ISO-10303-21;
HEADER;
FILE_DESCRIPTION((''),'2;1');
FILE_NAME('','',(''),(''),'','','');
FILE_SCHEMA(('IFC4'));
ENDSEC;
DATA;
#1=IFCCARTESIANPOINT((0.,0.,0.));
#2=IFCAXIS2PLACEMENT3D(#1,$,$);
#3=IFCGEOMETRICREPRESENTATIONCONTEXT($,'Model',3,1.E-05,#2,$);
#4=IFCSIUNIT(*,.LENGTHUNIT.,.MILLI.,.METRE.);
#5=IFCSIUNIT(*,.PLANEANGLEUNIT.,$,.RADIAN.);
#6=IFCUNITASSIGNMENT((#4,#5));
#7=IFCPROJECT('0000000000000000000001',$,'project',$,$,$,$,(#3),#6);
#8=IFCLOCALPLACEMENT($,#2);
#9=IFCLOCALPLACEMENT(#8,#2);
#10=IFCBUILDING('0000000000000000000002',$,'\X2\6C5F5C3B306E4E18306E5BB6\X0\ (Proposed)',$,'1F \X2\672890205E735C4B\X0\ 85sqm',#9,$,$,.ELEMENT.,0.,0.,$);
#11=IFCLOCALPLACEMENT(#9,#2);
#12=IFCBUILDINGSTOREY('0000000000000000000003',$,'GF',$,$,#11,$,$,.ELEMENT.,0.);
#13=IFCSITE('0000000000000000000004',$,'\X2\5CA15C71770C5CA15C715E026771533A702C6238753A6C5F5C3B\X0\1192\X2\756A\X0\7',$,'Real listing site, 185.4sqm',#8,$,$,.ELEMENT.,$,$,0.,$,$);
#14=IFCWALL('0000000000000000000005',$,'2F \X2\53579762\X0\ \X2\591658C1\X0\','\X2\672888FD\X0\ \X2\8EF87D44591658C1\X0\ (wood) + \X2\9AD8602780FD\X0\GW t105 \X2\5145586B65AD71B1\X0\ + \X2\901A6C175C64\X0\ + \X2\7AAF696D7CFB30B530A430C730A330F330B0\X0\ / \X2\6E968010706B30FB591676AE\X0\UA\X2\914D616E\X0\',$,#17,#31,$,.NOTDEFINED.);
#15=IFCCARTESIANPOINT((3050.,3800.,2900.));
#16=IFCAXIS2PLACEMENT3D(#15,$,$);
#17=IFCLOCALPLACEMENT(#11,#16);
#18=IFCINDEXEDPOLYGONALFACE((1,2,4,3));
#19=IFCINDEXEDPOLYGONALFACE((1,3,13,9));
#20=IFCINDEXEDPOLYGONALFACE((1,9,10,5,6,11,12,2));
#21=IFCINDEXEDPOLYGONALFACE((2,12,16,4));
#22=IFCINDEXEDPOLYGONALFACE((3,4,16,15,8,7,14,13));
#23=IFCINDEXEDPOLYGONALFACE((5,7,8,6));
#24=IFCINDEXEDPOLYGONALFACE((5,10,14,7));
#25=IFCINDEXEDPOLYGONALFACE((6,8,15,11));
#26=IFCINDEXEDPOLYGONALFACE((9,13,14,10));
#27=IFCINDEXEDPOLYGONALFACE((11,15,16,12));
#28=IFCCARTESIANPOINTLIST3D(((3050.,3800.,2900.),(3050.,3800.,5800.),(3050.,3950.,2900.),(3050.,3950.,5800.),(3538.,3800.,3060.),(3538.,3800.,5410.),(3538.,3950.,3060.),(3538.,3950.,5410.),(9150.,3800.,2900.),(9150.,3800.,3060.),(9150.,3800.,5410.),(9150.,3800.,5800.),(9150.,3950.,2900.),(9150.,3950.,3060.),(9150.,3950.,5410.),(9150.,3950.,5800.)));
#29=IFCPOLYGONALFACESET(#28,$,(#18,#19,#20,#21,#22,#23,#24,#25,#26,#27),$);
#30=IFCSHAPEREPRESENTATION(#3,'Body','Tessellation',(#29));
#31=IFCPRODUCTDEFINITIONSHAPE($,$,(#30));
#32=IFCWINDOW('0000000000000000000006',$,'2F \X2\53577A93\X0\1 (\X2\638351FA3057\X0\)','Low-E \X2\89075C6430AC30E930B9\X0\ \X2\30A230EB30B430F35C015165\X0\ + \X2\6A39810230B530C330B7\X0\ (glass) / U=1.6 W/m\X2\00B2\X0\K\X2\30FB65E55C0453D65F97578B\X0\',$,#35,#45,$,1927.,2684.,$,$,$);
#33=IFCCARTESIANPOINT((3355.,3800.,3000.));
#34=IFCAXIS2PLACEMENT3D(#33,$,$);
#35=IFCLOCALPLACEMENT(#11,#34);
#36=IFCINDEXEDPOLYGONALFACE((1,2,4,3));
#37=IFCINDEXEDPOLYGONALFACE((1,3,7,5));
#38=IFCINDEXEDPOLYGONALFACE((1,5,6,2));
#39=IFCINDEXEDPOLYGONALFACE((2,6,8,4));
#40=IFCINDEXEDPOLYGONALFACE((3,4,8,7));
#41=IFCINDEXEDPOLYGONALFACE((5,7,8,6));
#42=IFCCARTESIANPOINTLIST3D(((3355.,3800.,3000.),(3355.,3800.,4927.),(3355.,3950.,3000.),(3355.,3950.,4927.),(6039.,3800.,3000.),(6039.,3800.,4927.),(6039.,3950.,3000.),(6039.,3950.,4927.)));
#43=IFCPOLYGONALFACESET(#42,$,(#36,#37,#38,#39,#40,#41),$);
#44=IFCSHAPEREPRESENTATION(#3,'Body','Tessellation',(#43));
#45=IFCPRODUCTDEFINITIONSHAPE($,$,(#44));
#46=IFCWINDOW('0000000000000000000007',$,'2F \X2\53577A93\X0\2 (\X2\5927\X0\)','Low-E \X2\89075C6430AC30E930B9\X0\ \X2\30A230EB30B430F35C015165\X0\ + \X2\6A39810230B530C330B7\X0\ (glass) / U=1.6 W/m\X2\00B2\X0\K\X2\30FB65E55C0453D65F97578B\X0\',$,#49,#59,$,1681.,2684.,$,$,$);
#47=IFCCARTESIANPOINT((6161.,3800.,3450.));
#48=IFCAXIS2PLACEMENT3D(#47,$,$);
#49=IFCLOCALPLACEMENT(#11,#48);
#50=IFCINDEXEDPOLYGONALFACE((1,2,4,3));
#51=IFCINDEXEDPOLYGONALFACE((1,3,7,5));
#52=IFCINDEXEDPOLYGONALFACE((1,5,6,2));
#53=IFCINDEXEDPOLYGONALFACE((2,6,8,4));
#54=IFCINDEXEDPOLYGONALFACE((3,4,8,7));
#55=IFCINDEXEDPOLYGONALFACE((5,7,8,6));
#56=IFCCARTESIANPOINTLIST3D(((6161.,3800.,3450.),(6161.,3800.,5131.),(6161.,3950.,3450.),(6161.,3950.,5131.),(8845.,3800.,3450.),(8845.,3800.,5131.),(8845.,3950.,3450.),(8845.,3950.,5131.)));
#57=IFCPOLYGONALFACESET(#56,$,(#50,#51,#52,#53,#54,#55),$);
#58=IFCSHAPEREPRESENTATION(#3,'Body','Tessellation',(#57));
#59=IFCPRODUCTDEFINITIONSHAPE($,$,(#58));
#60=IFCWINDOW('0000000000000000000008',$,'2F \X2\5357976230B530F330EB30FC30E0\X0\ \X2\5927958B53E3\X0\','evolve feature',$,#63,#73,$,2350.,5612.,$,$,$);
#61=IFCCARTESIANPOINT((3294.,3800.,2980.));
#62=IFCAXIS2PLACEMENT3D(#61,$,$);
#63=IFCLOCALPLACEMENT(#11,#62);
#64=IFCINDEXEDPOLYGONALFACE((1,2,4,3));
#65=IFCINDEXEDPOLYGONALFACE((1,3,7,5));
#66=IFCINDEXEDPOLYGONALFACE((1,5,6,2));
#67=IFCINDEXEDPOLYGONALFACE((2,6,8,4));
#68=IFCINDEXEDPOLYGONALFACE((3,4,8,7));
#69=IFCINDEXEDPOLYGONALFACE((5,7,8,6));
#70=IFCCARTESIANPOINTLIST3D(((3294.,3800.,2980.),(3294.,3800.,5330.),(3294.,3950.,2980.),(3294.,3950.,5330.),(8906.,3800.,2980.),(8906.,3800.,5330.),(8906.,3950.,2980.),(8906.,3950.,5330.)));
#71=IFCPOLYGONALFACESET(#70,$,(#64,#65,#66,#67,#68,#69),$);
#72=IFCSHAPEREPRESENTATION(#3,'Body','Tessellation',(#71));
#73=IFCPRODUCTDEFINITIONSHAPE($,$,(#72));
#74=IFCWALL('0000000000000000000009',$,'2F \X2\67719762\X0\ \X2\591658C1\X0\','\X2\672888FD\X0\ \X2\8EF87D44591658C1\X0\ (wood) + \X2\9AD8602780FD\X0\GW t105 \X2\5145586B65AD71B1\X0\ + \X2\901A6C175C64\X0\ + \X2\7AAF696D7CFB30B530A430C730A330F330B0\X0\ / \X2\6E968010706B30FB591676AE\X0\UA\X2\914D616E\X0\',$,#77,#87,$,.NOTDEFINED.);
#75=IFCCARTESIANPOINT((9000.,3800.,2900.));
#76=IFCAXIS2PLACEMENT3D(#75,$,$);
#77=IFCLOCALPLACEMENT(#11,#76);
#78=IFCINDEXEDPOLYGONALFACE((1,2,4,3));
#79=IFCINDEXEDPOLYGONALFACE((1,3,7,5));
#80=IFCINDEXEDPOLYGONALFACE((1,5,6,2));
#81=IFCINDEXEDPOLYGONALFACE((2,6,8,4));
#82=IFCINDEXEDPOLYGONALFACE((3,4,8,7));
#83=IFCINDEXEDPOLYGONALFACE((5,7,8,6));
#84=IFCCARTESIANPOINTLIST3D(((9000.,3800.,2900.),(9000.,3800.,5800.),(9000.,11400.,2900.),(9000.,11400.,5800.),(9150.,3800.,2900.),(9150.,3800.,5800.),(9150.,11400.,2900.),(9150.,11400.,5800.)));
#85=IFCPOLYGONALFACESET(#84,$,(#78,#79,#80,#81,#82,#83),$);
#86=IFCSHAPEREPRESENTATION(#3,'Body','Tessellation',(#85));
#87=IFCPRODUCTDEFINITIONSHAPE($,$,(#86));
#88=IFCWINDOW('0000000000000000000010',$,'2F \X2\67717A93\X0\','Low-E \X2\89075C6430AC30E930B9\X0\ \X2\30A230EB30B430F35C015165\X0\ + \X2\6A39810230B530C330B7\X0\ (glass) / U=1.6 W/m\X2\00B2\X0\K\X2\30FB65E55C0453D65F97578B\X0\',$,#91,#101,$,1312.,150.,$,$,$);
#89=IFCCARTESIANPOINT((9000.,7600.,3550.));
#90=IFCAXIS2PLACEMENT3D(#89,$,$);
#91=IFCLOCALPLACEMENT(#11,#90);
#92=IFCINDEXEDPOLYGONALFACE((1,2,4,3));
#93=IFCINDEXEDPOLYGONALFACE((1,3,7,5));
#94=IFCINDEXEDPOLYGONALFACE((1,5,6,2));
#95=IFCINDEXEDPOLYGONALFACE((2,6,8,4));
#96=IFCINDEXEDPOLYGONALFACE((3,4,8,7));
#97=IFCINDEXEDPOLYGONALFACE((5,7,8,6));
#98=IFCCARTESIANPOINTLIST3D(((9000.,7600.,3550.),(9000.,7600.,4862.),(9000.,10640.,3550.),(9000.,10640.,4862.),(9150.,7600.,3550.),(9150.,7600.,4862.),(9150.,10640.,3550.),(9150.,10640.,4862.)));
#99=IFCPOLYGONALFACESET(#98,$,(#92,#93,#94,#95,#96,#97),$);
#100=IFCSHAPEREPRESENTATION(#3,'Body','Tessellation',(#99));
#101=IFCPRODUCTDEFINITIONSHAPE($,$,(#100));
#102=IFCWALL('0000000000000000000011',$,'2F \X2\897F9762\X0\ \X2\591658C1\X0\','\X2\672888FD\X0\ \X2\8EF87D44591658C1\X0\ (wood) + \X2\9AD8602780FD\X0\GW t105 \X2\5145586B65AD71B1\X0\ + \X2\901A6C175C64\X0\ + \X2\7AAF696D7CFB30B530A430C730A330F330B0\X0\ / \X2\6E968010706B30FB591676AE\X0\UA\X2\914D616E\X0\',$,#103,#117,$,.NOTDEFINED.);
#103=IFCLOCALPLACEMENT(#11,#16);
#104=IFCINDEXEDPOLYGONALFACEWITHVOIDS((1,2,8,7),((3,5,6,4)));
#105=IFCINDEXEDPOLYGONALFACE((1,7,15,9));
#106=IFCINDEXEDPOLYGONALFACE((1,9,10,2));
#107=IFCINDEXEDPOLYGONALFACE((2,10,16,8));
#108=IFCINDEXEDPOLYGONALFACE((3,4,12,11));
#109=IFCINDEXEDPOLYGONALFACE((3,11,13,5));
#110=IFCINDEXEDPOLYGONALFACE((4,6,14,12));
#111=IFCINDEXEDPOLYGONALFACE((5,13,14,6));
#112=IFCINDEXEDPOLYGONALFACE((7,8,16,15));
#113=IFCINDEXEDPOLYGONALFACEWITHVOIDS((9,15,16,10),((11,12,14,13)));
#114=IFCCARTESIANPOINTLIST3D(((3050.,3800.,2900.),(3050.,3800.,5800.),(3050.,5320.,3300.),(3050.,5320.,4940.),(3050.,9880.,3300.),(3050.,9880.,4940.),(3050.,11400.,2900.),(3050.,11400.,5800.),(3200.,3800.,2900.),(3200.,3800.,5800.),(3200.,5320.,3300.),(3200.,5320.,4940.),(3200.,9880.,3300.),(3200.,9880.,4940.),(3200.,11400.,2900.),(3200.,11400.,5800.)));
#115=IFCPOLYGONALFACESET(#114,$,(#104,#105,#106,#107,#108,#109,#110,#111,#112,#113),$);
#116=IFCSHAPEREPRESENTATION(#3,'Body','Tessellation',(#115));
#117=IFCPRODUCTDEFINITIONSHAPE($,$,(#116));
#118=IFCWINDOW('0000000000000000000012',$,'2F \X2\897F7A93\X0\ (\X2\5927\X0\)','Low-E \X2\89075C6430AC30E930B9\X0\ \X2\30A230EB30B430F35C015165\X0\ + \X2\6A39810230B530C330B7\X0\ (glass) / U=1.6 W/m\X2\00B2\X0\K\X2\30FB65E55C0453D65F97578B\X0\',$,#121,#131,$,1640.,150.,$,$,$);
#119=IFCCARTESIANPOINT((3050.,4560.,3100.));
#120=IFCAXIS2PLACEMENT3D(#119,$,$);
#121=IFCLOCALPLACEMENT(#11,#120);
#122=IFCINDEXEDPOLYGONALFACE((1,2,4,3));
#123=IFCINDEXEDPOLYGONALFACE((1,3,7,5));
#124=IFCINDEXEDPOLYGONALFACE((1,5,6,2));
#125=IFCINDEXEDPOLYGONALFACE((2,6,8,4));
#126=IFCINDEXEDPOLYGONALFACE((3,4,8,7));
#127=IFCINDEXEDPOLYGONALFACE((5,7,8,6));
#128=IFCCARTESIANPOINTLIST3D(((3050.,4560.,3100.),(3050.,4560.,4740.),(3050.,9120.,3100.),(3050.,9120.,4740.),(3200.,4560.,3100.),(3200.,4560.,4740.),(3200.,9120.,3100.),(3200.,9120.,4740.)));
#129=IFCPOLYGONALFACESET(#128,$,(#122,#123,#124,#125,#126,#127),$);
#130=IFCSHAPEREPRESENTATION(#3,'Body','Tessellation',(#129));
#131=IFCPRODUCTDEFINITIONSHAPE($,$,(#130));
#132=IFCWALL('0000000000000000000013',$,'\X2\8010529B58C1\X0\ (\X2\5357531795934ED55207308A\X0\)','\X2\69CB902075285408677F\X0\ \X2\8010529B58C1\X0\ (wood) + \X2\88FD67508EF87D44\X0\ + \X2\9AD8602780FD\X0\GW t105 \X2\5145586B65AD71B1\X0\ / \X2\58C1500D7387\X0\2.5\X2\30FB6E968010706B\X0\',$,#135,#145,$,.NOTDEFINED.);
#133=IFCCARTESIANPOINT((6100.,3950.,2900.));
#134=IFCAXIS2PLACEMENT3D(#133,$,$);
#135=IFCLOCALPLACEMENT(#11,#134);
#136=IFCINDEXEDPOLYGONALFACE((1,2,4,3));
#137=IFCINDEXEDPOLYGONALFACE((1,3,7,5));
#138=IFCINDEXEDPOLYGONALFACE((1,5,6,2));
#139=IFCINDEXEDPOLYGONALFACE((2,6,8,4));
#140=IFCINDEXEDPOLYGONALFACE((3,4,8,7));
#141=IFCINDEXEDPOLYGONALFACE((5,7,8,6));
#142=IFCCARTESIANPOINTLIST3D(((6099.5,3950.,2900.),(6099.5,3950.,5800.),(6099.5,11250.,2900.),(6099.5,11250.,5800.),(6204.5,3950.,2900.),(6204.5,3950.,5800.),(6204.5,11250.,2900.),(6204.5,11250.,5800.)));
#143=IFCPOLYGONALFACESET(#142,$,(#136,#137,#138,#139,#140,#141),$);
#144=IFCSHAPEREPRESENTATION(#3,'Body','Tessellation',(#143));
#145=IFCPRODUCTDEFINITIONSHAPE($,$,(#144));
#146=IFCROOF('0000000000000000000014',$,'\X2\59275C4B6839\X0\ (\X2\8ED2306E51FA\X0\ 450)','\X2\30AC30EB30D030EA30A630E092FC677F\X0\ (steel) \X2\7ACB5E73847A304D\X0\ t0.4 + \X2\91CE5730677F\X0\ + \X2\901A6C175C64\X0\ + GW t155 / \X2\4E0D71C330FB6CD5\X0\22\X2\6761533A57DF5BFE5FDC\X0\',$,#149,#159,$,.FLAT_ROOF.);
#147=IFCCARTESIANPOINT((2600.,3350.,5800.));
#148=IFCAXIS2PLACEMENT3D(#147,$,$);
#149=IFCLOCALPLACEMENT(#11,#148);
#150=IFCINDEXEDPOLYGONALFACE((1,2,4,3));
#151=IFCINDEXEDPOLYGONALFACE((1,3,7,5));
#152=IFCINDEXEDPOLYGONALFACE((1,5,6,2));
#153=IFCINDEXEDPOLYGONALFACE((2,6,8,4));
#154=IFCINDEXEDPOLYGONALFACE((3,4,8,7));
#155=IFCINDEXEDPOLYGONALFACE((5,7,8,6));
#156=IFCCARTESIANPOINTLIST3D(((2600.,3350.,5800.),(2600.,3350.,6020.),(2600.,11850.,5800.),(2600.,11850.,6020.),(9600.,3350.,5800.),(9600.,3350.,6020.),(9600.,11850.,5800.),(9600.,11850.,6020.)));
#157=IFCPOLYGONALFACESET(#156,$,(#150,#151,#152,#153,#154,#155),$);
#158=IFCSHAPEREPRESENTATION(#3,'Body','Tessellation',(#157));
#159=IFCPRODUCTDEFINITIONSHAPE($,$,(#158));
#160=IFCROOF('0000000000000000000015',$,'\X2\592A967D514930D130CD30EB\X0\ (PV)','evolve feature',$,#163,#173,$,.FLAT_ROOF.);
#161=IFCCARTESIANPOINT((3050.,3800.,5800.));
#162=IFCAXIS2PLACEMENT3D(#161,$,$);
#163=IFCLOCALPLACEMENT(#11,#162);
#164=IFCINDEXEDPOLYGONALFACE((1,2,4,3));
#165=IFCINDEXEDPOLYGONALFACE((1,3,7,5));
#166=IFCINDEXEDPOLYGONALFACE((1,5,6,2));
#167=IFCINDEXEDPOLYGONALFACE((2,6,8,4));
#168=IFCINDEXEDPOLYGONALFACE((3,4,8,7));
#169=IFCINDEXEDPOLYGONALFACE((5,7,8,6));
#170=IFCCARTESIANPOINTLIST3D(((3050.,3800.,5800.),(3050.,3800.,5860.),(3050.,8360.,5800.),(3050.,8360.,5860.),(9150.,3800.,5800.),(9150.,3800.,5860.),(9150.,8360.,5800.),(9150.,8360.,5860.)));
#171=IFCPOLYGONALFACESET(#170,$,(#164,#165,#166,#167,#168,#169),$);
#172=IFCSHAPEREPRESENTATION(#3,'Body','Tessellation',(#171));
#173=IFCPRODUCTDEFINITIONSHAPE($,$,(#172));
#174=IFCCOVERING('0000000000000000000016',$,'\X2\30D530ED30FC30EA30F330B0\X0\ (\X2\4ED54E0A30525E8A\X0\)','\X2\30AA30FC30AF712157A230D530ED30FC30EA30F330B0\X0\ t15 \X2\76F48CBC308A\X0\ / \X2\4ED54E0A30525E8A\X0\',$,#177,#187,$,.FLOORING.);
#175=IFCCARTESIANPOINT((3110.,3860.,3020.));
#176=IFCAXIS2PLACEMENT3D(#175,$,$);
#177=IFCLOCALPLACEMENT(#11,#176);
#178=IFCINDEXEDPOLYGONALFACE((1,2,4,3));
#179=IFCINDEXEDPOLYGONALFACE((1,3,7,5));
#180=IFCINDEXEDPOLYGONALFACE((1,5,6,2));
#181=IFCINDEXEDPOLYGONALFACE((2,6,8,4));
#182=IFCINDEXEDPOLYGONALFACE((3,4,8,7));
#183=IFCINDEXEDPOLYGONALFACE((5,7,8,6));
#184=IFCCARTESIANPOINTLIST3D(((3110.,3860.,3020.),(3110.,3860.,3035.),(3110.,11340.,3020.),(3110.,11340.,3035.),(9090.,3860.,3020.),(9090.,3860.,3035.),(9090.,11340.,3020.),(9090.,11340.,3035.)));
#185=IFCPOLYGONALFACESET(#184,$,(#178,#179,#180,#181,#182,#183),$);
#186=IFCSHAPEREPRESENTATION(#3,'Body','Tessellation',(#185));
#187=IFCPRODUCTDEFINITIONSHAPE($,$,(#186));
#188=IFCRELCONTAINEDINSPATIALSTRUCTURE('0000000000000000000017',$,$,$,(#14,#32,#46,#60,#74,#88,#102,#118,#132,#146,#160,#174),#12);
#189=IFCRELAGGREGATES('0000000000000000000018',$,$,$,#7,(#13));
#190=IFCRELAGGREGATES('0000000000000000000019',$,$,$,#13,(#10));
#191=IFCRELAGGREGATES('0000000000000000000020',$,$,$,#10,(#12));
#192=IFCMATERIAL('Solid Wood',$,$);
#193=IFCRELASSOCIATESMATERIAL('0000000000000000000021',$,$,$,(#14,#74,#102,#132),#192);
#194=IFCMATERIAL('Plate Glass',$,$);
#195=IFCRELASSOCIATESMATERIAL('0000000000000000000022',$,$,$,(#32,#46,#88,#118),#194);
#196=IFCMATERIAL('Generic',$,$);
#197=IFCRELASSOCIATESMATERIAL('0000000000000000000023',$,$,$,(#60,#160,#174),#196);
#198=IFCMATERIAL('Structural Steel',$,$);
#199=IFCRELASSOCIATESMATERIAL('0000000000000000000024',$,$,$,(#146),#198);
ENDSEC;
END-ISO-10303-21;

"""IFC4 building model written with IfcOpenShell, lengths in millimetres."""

from ifc_helpers import new_model, si_unit, frame, frame_2d, origin, place, context, project, spatial, rectangle, extrude, material, element, fill, save


model = new_model("IFC4")

# Units and contexts
model_context = context("Model", 3, precision=1e-05, world=origin())
ifc_project = project(units=[si_unit("LENGTHUNIT", "METRE", prefix="MILLI"), si_unit("PLANEANGLEUNIT", "RADIAN")], contexts=[model_context])

# Site, building, storey
site_placement = place(None, origin())
site = spatial("IfcSite", under=ifc_project, at=site_placement, Name="岡山県岡山市東区瀬戸町江尻1192番7", ObjectType="Real listing site, 185.4sqm", CompositionType="ELEMENT", RefElevation=0.0)
building_placement = place(site_placement, origin())
building = spatial("IfcBuilding", under=site, at=building_placement, Name="江尻の丘の家 (Proposed)", ObjectType="1F 木造平屋 85sqm", CompositionType="ELEMENT", ElevationOfRefHeight=0.0, ElevationOfTerrain=0.0)
storey_placement = place(building_placement, origin())
storey = spatial("IfcBuildingStorey", under=building, at=storey_placement, Name="GF", CompositionType="ELEMENT", Elevation=0.0)

# Shared definitions
ifc_material_1 = material(Name="Solid Wood")

# Wall, openings, windows
wall_1_placement = place(storey_placement, frame((3050.0, 3800.0, 2900.0)))
wall_1 = element("IfcWall", 1, at=wall_1_placement, inside=storey, material=ifc_material_1, Name="2F 南面 外壁", Description="木製 軸組外壁 (wood) + 高性能GW t105 充填断熱 + 通気層 + 窯業系サイディング / 準耐火・外皮UA配慮", PredefinedType="NOTDEFINED", context=model_context, shape_type="SweptSolid", body=[
    extrude(rectangle(XDim=6100.0, YDim=150.0, at=frame_2d((3050.0, 75.0))), frame((3050.0, 3800.0, 2900.0)), (0.0, 0.0, 1.0), 2900.0),
])
opening_1_placement = place(storey_placement, frame((3355.0, 3800.0, 3000.0)))
opening_1 = element("IfcOpeningElement", 2, at=opening_1_placement, cuts=wall_1, PredefinedType="NOTDEFINED", context=model_context, shape_type="SweptSolid", body=[
    extrude(rectangle(XDim=2684.0, YDim=150.0, at=frame_2d((1342.0, 75.0))), frame((3355.0, 3800.0, 3000.0)), (0.0, 0.0, 1.0), 1927.0),
])
opening_2_placement = place(storey_placement, frame((6161.0, 3800.0, 3450.0)))
opening_2 = element("IfcOpeningElement", 3, at=opening_2_placement, cuts=wall_1, PredefinedType="NOTDEFINED", context=model_context, shape_type="SweptSolid", body=[
    extrude(rectangle(XDim=2684.0, YDim=150.0, at=frame_2d((1342.0, 75.0))), frame((6161.0, 3800.0, 3450.0)), (0.0, 0.0, 1.0), 1681.0),
])
opening_3_placement = place(storey_placement, frame((3294.0, 3800.0, 2980.0)))
opening_3 = element("IfcOpeningElement", 4, at=opening_3_placement, cuts=wall_1, PredefinedType="NOTDEFINED", context=model_context, shape_type="SweptSolid", body=[
    extrude(rectangle(XDim=5612.0, YDim=150.0, at=frame_2d((2806.0, 75.0))), frame((3294.0, 3800.0, 2980.0)), (0.0, 0.0, 1.0), 2350.0),
])
ifc_material_2 = material(Name="Plate Glass")
window_1_placement = place(storey_placement, frame((3355.0, 3800.0, 3000.0)))
window_1 = element("IfcWindow", 5, at=window_1_placement, inside=storey, material=ifc_material_2, Name="2F 南窓1 (掃出し)", Description="Low-E 複層ガラス アルゴン封入 + 樹脂サッシ (glass) / U=1.6 W/m²K・日射取得型", OverallHeight=1927.0, OverallWidth=2684.0, context=model_context, shape_type="SweptSolid", body=[
    extrude(rectangle(XDim=2684.0, YDim=150.0, at=frame_2d((1342.0, 75.0))), frame((3355.0, 3800.0, 3000.0)), (0.0, 0.0, 1.0), 1927.0),
])
fill(opening_1, window_1)
window_2_placement = place(storey_placement, frame((6161.0, 3800.0, 3450.0)))
window_2 = element("IfcWindow", 6, at=window_2_placement, inside=storey, material=ifc_material_2, Name="2F 南窓2 (大)", Description="Low-E 複層ガラス アルゴン封入 + 樹脂サッシ (glass) / U=1.6 W/m²K・日射取得型", OverallHeight=1681.0, OverallWidth=2684.0, context=model_context, shape_type="SweptSolid", body=[
    extrude(rectangle(XDim=2684.0, YDim=150.0, at=frame_2d((1342.0, 75.0))), frame((6161.0, 3800.0, 3450.0)), (0.0, 0.0, 1.0), 1681.0),
])
fill(opening_2, window_2)
ifc_material_3 = material(Name="Generic")
window_3_placement = place(storey_placement, frame((3294.0, 3800.0, 2980.0)))
window_3 = element("IfcWindow", 7, at=window_3_placement, inside=storey, material=ifc_material_3, Name="2F 南面サンルーム 大開口", Description="evolve feature", OverallHeight=2350.0, OverallWidth=5612.0, context=model_context, shape_type="SweptSolid", body=[
    extrude(rectangle(XDim=5612.0, YDim=150.0, at=frame_2d((2806.0, 75.0))), frame((3294.0, 3800.0, 2980.0)), (0.0, 0.0, 1.0), 2350.0),
])
fill(opening_3, window_3)

# Walls, openings, windows
wall_2_placement = place(storey_placement, frame((9000.0, 3800.0, 2900.0)))
wall_2 = element("IfcWall", 8, at=wall_2_placement, inside=storey, material=ifc_material_1, Name="2F 東面 外壁", Description="木製 軸組外壁 (wood) + 高性能GW t105 充填断熱 + 通気層 + 窯業系サイディング / 準耐火・外皮UA配慮", PredefinedType="NOTDEFINED", context=model_context, shape_type="SweptSolid", body=[
    extrude(rectangle(XDim=150.0, YDim=7600.0, at=frame_2d((75.0, 3800.0))), frame((9000.0, 3800.0, 2900.0)), (0.0, 0.0, 1.0), 2900.0),
])
opening_4_placement = place(storey_placement, frame((9000.0, 7600.0, 3550.0)))
opening_4 = element("IfcOpeningElement", 9, at=opening_4_placement, cuts=wall_2, PredefinedType="NOTDEFINED", context=model_context, shape_type="SweptSolid", body=[
    extrude(rectangle(XDim=150.0, YDim=3040.0, at=frame_2d((75.0, 1520.0))), frame((9000.0, 7600.0, 3550.0)), (0.0, 0.0, 1.0), 1312.0),
])
window_4_placement = place(storey_placement, frame((9000.0, 7600.0, 3550.0)))
window_4 = element("IfcWindow", 10, at=window_4_placement, inside=storey, material=ifc_material_2, Name="2F 東窓", Description="Low-E 複層ガラス アルゴン封入 + 樹脂サッシ (glass) / U=1.6 W/m²K・日射取得型", OverallHeight=1312.0, OverallWidth=150.0, context=model_context, shape_type="SweptSolid", body=[
    extrude(rectangle(XDim=150.0, YDim=3040.0, at=frame_2d((75.0, 1520.0))), frame((9000.0, 7600.0, 3550.0)), (0.0, 0.0, 1.0), 1312.0),
])
fill(opening_4, window_4)
wall_3_placement = place(storey_placement, frame((3050.0, 3800.0, 2900.0)))
wall_3 = element("IfcWall", 11, at=wall_3_placement, inside=storey, material=ifc_material_1, Name="2F 西面 外壁", Description="木製 軸組外壁 (wood) + 高性能GW t105 充填断熱 + 通気層 + 窯業系サイディング / 準耐火・外皮UA配慮", PredefinedType="NOTDEFINED", context=model_context, shape_type="SweptSolid", body=[
    extrude(rectangle(XDim=150.0, YDim=7600.0, at=frame_2d((75.0, 3800.0))), frame((3050.0, 3800.0, 2900.0)), (0.0, 0.0, 1.0), 2900.0),
])
opening_5_placement = place(storey_placement, frame((3050.0, 4560.0, 3100.0)))
opening_5 = element("IfcOpeningElement", 12, at=opening_5_placement, cuts=wall_3, PredefinedType="NOTDEFINED", context=model_context, shape_type="SweptSolid", body=[
    extrude(rectangle(XDim=150.0, YDim=4560.0, at=frame_2d((75.0, 2280.0))), frame((3050.0, 4560.0, 3100.0)), (0.0, 0.0, 1.0), 1640.0),
])
window_5_placement = place(storey_placement, frame((3050.0, 4560.0, 3100.0)))
window_5 = element("IfcWindow", 13, at=window_5_placement, inside=storey, material=ifc_material_2, Name="2F 西窓 (大)", Description="Low-E 複層ガラス アルゴン封入 + 樹脂サッシ (glass) / U=1.6 W/m²K・日射取得型", OverallHeight=1640.0, OverallWidth=150.0, context=model_context, shape_type="SweptSolid", body=[
    extrude(rectangle(XDim=150.0, YDim=4560.0, at=frame_2d((75.0, 2280.0))), frame((3050.0, 4560.0, 3100.0)), (0.0, 0.0, 1.0), 1640.0),
])
fill(opening_5, window_5)

# Wall
wall_4_placement = place(storey_placement, frame((6100.0, 3950.0, 2900.0)))
element("IfcWall", 14, at=wall_4_placement, inside=storey, material=ifc_material_1, Name="耐力壁 (南北間仕切り)", Description="構造用合板 耐力壁 (wood) + 製材軸組 + 高性能GW t105 充填断熱 / 壁倍率2.5・準耐火", PredefinedType="NOTDEFINED", context=model_context, shape_type="SweptSolid", body=[
    extrude(rectangle(XDim=105.0, YDim=7300.0, at=frame_2d((52.0, 3650.0))), frame((6100.0, 3950.0, 2900.0)), (0.0, 0.0, 1.0), 2900.0),
])

# Roofs
ifc_material_4 = material(Name="Structural Steel")
roof_1_placement = place(storey_placement, frame((2600.0, 3350.0, 5800.0)))
element("IfcRoof", 15, at=roof_1_placement, inside=storey, material=ifc_material_4, Name="大屋根 (軒の出 450)", Description="ガルバリウム鋼板 (steel) 立平葺き t0.4 + 野地板 + 通気層 + GW t155 / 不燃・法22条区域対応", PredefinedType="FLAT_ROOF", context=model_context, shape_type="SweptSolid", body=[
    extrude(rectangle(XDim=7000.0, YDim=8500.0, at=frame_2d((3500.0, 4250.0))), frame((2600.0, 3350.0, 5800.0)), (0.0, 0.0, 1.0), 220.0),
])
roof_2_placement = place(storey_placement, frame((3050.0, 3800.0, 5800.0)))
element("IfcRoof", 16, at=roof_2_placement, inside=storey, material=ifc_material_3, Name="太陽光パネル (PV)", Description="evolve feature", PredefinedType="FLAT_ROOF", context=model_context, shape_type="SweptSolid", body=[
    extrude(rectangle(XDim=6100.0, YDim=4560.0, at=frame_2d((3050.0, 2280.0))), frame((3050.0, 3800.0, 5800.0)), (0.0, 0.0, 1.0), 60.0),
])

# Covering
covering_placement = place(storey_placement, frame((3110.0, 3860.0, 3020.0)))
element("IfcCovering", 17, at=covering_placement, inside=storey, material=ifc_material_3, Name="フローリング (仕上げ床)", Description="オーク無垢フローリング t15 直貼り / 仕上げ床", PredefinedType="FLOORING", context=model_context, shape_type="SweptSolid", body=[
    extrude(rectangle(XDim=5980.0, YDim=7480.0, at=frame_2d((2990.0, 3740.0))), frame((3110.0, 3860.0, 3020.0)), (0.0, 0.0, 1.0), 15.0),
])

save(model, "model.ifc")
